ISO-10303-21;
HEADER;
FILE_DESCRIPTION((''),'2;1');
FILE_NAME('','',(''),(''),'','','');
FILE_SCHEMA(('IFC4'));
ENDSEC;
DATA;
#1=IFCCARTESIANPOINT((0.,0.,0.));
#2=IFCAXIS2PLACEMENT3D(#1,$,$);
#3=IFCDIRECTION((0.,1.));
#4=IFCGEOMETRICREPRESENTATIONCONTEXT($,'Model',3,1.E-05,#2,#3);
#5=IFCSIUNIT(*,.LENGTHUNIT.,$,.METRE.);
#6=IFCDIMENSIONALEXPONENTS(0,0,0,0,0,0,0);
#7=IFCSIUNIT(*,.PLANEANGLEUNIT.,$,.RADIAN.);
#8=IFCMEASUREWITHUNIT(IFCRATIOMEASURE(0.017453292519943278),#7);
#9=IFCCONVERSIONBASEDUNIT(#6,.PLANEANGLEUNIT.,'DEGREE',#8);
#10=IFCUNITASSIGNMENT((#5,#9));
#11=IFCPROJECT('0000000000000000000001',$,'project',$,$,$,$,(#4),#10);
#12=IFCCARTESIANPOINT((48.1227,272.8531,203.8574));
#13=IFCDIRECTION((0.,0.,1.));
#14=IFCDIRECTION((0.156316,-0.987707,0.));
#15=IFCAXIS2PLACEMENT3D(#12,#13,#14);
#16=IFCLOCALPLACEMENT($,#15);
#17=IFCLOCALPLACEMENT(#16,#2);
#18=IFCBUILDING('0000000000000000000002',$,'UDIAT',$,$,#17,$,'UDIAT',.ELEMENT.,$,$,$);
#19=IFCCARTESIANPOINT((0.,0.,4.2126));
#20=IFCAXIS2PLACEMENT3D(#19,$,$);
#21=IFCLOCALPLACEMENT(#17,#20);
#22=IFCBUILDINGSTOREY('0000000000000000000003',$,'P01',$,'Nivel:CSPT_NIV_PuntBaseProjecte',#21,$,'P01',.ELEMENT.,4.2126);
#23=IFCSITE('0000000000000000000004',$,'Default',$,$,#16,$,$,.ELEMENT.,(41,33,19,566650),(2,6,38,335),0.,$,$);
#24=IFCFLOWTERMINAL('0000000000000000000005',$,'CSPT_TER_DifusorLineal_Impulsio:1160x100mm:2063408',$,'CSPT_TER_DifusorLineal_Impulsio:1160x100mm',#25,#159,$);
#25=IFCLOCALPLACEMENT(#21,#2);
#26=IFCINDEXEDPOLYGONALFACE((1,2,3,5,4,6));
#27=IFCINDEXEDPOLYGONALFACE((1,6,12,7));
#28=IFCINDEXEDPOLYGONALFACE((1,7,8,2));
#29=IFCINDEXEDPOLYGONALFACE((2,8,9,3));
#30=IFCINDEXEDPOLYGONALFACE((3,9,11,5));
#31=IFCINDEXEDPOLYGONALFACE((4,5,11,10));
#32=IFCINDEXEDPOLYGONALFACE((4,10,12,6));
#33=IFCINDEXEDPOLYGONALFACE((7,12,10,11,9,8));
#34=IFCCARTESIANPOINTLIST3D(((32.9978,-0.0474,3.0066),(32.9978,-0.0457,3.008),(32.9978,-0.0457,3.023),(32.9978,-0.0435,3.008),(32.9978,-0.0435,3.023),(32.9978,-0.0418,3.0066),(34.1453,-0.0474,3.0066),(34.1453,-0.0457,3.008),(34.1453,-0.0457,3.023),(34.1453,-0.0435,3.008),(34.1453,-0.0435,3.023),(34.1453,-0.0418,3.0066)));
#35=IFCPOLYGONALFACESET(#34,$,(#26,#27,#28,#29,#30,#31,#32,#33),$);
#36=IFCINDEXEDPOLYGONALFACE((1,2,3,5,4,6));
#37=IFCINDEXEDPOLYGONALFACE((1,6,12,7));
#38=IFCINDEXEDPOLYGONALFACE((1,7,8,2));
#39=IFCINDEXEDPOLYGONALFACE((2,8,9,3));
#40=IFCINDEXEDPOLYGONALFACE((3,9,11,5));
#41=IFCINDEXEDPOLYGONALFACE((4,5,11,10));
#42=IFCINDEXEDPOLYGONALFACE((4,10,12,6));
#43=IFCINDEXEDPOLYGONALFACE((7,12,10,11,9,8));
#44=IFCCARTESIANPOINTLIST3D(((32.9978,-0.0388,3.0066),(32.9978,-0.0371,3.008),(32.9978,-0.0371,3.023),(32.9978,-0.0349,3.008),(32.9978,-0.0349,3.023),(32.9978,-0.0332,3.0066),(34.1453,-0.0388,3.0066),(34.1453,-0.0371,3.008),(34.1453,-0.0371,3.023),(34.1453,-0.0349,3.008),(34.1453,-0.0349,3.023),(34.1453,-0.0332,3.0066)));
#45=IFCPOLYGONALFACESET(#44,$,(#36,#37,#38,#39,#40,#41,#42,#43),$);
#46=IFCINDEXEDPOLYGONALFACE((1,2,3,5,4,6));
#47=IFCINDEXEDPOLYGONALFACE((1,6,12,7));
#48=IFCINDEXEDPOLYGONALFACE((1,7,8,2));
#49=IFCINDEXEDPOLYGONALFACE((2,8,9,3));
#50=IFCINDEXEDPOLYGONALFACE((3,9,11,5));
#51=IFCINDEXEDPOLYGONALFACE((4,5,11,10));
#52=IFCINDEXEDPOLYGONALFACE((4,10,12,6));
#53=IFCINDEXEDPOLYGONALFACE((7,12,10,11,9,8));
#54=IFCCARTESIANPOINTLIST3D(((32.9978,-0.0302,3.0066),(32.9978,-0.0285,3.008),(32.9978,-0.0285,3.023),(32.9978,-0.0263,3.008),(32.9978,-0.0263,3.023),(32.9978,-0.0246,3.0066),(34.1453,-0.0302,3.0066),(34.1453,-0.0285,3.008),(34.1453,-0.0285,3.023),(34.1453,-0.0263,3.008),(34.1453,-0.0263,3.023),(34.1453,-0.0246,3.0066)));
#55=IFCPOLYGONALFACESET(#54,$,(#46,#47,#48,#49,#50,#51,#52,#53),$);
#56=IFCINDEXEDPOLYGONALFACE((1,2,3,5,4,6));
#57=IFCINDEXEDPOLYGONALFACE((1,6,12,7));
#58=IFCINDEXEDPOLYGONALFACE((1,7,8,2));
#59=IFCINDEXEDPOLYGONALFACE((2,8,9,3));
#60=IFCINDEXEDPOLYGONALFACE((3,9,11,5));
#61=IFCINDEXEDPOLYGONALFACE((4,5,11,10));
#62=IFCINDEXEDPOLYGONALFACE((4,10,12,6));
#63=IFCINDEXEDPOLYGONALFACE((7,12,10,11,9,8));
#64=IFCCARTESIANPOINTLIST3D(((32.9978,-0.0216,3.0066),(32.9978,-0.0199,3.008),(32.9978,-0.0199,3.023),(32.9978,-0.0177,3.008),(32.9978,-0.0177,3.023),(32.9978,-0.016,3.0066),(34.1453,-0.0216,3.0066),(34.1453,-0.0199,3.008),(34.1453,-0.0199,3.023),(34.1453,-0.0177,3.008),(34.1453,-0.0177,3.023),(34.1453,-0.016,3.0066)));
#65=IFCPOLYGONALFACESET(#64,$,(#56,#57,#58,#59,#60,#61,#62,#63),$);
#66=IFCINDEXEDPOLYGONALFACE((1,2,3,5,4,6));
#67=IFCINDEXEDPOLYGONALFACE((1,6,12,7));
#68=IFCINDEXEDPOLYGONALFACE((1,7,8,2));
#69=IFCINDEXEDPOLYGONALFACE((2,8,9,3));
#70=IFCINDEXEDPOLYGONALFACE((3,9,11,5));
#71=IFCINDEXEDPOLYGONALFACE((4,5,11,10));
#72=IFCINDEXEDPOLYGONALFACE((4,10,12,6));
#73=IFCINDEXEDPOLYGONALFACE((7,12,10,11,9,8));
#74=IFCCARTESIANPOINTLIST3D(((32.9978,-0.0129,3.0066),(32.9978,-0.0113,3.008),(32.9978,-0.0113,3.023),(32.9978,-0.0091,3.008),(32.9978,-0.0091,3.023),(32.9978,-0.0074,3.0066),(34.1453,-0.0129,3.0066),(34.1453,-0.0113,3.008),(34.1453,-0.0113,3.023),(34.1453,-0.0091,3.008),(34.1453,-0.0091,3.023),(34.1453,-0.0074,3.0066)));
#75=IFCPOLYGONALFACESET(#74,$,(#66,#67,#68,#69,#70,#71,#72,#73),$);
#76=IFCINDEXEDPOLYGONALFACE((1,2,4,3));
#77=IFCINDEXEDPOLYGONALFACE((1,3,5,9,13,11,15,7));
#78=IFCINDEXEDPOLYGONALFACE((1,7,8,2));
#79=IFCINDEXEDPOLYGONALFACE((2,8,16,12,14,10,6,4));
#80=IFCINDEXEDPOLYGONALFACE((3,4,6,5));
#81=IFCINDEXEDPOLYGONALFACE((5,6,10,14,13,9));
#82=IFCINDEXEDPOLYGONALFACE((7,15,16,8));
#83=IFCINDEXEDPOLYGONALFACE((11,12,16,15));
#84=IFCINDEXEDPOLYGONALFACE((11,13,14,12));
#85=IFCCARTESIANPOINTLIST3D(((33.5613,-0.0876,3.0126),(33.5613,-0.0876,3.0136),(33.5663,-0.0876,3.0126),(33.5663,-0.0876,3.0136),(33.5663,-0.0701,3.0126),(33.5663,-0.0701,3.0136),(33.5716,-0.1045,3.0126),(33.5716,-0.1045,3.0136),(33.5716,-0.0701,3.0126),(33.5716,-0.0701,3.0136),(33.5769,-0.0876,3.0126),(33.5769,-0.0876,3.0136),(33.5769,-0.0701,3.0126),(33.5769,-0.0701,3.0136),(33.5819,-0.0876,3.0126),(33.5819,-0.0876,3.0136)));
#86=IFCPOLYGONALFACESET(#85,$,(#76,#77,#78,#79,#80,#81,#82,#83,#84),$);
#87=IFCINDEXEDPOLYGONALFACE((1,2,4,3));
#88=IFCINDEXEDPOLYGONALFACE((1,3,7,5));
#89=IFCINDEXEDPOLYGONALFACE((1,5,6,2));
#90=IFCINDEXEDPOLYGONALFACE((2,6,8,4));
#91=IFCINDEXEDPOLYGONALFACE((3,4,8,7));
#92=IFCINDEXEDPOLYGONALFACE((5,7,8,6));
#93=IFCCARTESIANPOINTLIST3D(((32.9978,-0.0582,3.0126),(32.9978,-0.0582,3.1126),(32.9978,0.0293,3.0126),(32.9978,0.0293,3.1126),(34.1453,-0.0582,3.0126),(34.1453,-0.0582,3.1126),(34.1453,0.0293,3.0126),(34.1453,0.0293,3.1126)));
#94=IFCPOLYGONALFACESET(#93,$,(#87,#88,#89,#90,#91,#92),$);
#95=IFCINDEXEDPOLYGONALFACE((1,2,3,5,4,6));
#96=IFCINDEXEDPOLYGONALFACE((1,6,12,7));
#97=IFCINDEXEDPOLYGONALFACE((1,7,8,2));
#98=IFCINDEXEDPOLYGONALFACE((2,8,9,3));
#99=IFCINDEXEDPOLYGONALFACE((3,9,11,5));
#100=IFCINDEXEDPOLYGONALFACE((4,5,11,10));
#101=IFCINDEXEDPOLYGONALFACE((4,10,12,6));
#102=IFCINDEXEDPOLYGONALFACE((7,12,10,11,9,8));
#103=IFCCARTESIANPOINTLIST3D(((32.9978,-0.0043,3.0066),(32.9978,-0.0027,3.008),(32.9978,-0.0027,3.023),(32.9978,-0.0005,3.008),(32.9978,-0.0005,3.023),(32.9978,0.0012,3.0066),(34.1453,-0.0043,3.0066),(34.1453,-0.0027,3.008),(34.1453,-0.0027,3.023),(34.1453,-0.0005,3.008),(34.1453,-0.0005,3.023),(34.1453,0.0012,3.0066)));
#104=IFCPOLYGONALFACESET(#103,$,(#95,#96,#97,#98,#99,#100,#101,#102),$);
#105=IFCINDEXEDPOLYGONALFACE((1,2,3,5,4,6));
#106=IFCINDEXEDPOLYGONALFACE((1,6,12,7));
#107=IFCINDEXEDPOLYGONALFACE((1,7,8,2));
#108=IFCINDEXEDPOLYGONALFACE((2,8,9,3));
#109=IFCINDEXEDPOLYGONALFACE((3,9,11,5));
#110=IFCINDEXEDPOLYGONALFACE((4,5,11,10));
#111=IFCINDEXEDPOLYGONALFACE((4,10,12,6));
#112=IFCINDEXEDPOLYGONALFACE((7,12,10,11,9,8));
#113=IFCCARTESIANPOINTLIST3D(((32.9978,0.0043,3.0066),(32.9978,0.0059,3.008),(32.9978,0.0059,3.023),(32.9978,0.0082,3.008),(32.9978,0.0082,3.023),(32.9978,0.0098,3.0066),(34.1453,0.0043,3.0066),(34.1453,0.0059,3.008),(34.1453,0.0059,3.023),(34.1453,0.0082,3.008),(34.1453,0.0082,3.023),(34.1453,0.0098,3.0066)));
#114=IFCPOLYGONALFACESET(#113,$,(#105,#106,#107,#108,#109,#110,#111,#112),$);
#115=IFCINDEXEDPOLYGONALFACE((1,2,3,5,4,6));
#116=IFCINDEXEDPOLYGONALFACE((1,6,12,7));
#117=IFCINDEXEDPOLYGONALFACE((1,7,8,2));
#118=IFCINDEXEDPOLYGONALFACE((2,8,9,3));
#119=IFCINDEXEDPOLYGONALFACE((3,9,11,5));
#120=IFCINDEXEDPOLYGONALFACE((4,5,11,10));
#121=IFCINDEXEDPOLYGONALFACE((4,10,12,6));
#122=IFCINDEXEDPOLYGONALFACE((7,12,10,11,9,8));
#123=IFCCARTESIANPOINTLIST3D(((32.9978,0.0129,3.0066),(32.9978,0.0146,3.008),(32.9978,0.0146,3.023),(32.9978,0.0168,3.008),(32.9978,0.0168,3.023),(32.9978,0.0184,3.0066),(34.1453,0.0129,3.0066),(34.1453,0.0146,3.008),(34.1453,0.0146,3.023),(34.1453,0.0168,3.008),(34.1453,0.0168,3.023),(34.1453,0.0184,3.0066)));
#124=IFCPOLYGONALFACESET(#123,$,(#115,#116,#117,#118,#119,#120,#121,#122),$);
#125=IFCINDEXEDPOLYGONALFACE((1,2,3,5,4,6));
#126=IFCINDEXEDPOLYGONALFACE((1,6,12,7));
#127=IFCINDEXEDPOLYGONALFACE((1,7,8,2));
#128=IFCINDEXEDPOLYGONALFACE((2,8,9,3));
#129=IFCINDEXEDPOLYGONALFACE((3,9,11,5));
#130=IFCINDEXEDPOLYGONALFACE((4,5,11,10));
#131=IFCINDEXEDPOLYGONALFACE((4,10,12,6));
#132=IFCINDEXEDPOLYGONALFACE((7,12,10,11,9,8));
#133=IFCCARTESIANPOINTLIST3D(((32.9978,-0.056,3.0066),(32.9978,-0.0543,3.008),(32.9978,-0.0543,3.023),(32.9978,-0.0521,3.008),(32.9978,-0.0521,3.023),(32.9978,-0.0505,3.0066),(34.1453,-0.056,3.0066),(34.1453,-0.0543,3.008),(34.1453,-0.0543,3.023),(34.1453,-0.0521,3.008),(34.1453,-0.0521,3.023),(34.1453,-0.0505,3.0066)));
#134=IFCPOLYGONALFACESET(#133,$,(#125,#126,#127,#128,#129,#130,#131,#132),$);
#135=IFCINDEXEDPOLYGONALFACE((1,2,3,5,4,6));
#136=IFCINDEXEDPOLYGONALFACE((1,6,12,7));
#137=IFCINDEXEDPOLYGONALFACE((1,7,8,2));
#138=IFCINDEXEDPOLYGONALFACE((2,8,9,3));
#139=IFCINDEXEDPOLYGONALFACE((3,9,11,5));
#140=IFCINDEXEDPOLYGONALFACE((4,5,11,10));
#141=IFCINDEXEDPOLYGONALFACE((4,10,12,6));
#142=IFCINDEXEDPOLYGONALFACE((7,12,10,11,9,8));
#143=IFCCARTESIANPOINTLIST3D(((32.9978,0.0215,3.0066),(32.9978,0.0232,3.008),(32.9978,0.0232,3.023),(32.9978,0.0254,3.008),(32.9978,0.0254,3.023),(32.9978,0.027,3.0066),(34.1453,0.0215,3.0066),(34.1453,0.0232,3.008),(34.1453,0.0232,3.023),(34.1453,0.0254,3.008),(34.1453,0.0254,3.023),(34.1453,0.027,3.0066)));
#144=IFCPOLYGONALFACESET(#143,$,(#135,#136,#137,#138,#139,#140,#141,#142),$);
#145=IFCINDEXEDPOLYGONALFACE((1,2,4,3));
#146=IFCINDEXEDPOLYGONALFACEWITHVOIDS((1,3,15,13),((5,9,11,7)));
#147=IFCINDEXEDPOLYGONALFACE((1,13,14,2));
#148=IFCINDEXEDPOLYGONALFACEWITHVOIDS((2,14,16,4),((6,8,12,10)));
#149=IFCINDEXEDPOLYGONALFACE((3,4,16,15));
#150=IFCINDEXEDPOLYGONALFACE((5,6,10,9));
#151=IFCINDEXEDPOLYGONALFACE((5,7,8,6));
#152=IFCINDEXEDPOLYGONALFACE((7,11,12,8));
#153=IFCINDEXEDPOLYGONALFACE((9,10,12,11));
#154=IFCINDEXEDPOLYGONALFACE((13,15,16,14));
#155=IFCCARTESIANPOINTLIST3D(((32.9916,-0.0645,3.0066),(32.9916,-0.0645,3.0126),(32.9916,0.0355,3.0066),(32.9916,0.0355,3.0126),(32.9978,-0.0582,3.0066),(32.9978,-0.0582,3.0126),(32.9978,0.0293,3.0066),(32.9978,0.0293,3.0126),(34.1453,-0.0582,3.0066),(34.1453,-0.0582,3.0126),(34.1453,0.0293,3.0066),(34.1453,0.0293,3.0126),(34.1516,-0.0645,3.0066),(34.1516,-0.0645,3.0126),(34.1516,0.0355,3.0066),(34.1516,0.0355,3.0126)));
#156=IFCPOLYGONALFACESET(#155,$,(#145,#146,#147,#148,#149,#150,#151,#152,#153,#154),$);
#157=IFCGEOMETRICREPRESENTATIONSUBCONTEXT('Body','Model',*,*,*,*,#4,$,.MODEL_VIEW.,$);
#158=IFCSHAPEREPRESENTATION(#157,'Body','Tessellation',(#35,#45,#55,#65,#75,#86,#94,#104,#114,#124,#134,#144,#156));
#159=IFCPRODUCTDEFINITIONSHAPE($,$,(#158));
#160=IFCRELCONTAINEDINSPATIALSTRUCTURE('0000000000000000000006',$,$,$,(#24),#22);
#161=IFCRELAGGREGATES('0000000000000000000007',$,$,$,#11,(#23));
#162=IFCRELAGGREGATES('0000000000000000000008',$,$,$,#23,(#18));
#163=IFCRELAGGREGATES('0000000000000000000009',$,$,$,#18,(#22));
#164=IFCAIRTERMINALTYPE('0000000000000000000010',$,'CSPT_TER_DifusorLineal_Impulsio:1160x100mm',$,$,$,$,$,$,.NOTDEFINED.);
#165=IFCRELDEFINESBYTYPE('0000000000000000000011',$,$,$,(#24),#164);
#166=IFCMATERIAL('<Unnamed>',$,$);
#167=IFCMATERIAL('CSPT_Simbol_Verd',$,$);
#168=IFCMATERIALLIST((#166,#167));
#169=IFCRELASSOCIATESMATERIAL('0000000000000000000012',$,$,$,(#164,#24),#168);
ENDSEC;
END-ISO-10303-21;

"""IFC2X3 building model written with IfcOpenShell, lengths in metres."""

from ifc_helpers import new_model, entity, si_unit, converted_unit, direction, frame, origin, origin_2d_with_axis, place, context, subcontext, project, spatial, polyline, rectangle, outline, extrude, source, transform, mapped, material, material_list, type_object, type_shapes, element, save


model = new_model("IFC2X3")

# Units and contexts
model_context = context("Model", 3, precision=1e-05, world=origin(), true_north=direction((0.0, 1.0)))
body_context = subcontext(model_context, "Body", "Model", "MODEL_VIEW")
ifc_project = project(units=[si_unit("LENGTHUNIT", "METRE"), converted_unit("PLANEANGLEUNIT", "DEGREE", entity("IfcRatioMeasure", 0.017453292519943278), si_unit("PLANEANGLEUNIT", "RADIAN"), dimensions=[0, 0, 0, 0, 0, 0, 0])], contexts=[model_context])

# Site, building, storey
site_placement = place(None, frame((48.1227, 272.8531, 203.8574), z_axis=(0.0, 0.0, 1.0), x_axis=(0.156316, -0.987707, 0.0)))
site = spatial("IfcSite", under=ifc_project, at=site_placement, Name="Default", CompositionType="ELEMENT", RefLatitude=(41, 33, 19, 566650), RefLongitude=(2, 6, 38, 335), RefElevation=0.0)
building_placement = place(site_placement, origin())
building = spatial("IfcBuilding", under=site, at=building_placement, Name="UDIAT", LongName="UDIAT", CompositionType="ELEMENT")
storey_placement = place(building_placement, frame((0.0, 0.0, 4.2126)))
storey = spatial("IfcBuildingStorey", under=building, at=storey_placement, Name="P01", ObjectType="Nivel:CSPT_NIV_PuntBaseProjecte", LongName="P01", CompositionType="ELEMENT", Elevation=4.2126)

# Shared definitions
ifc_material_1 = material(Name="<Unnamed>")

# Flow terminal
ifc_material_2 = material(Name="CSPT_Simbol_Verd")
ifc_material_list = material_list([ifc_material_1, ifc_material_2])
air_terminal_type = type_object("IfcAirTerminalType", Name="CSPT_TER_DifusorLineal_Impulsio:1160x100mm", PredefinedType="NOTDEFINED", material=ifc_material_list)
shared_shape_1 = source(origin(), body_context, "Body", "SweptSolid", [
    extrude(outline(polyline([(0.0037, 0.0028), (0.0059, 0.0028), (0.0016, 0.0063), (0.002, 0.0042), (-0.0074, -0.0074), (-0.0057, -0.0088), (0.0037, 0.0028)])), frame((-0.5737, 0.0301, -0.0001), z_axis=(1.0, 0.0, 0.0), x_axis=(0.0, -0.776119, -0.630587)), (0.0, 0.0, 1.0), 1.1475),
    extrude(outline(polyline([(0.0037, 0.0028), (0.0059, 0.0028), (0.0016, 0.0063), (0.002, 0.0042), (-0.0074, -0.0074), (-0.0057, -0.0088), (0.0037, 0.0028)])), frame((-0.5737, 0.0215, -0.0001), z_axis=(1.0, 0.0, 0.0), x_axis=(0.0, -0.776119, -0.630587)), (0.0, 0.0, 1.0), 1.1475),
    extrude(outline(polyline([(0.0037, 0.0028), (0.0059, 0.0028), (0.0016, 0.0063), (0.002, 0.0042), (-0.0074, -0.0074), (-0.0057, -0.0088), (0.0037, 0.0028)])), frame((-0.5737, 0.0129, -0.0001), z_axis=(1.0, 0.0, 0.0), x_axis=(0.0, -0.776119, -0.630587)), (0.0, 0.0, 1.0), 1.1475),
    extrude(outline(polyline([(0.0037, 0.0028), (0.0059, 0.0028), (0.0016, 0.0063), (0.002, 0.0042), (-0.0074, -0.0074), (-0.0057, -0.0088), (0.0037, 0.0028)])), frame((-0.5737, 0.0043, -0.0001), z_axis=(1.0, 0.0, 0.0), x_axis=(0.0, -0.776119, -0.630587)), (0.0, 0.0, 1.0), 1.1475),
    extrude(outline(polyline([(0.0037, 0.0028), (0.0059, 0.0028), (0.0016, 0.0063), (0.002, 0.0042), (-0.0074, -0.0074), (-0.0057, -0.0088), (0.0037, 0.0028)])), frame((-0.5737, -0.0043, -0.0001), z_axis=(1.0, 0.0, 0.0), x_axis=(0.0, -0.776119, -0.630587)), (0.0, 0.0, 1.0), 1.1475),
    extrude(outline(polyline([(0.0, -0.013), (0.0053, -0.013), (0.0053, 0.0045), (0.0103, 0.0045), (0.0, 0.0213), (-0.0103, 0.0045), (-0.0053, 0.0045), (-0.0053, -0.013), (0.0, -0.013)])), frame((0.0, 0.0687, 0.0)), (0.0, 0.0, 1.0), 0.001),
    extrude(rectangle(XDim=1.1475, YDim=0.0875, at=origin_2d_with_axis()), frame((0.0, 0.0, 0.0), z_axis=(0.0, 0.0, 1.0), x_axis=(-1.0, 0.0, 0.0)), (0.0, 0.0, 1.0), 0.1),
    extrude(outline(polyline([(0.0037, 0.0028), (0.0059, 0.0028), (0.0016, 0.0063), (0.002, 0.0042), (-0.0074, -0.0074), (-0.0057, -0.0088), (0.0037, 0.0028)])), frame((-0.5737, -0.0129, -0.0001), z_axis=(1.0, 0.0, 0.0), x_axis=(0.0, -0.776119, -0.630587)), (0.0, 0.0, 1.0), 1.1475),
    extrude(outline(polyline([(0.0037, 0.0028), (0.0059, 0.0028), (0.0016, 0.0063), (0.002, 0.0042), (-0.0074, -0.0074), (-0.0057, -0.0088), (0.0037, 0.0028)])), frame((-0.5737, -0.0215, -0.0001), z_axis=(1.0, 0.0, 0.0), x_axis=(0.0, -0.776119, -0.630587)), (0.0, 0.0, 1.0), 1.1475),
    extrude(outline(polyline([(0.0037, 0.0028), (0.0059, 0.0028), (0.0016, 0.0063), (0.002, 0.0042), (-0.0074, -0.0074), (-0.0057, -0.0088), (0.0037, 0.0028)])), frame((-0.5737, -0.0301, -0.0001), z_axis=(1.0, 0.0, 0.0), x_axis=(0.0, -0.776119, -0.630587)), (0.0, 0.0, 1.0), 1.1475),
    extrude(outline(polyline([(0.0037, 0.0028), (0.0059, 0.0028), (0.0016, 0.0063), (0.002, 0.0042), (-0.0074, -0.0074), (-0.0057, -0.0088), (0.0037, 0.0028)])), frame((-0.5737, 0.0388, -0.0001), z_axis=(1.0, 0.0, 0.0), x_axis=(0.0, -0.776119, -0.630587)), (0.0, 0.0, 1.0), 1.1475),
    extrude(outline(polyline([(0.0037, 0.0028), (0.0059, 0.0028), (0.0016, 0.0063), (0.002, 0.0042), (-0.0074, -0.0074), (-0.0057, -0.0088), (0.0037, 0.0028)])), frame((-0.5737, -0.0387, -0.0001), z_axis=(1.0, 0.0, 0.0), x_axis=(0.0, -0.776119, -0.630587)), (0.0, 0.0, 1.0), 1.1475),
    extrude(outline(polyline([(-0.58, -0.05), (0.58, -0.05), (0.58, 0.05), (-0.58, 0.05), (-0.58, -0.05)]), holes=[polyline([(-0.5738, -0.0438), (-0.5738, 0.0437), (0.5737, 0.0437), (0.5737, -0.0438), (-0.5738, -0.0438)])]), frame((0.0, 0.0, -0.006), z_axis=(0.0, 0.0, 1.0), x_axis=(-1.0, 0.0, 0.0)), (0.0, 0.0, 1.0), 0.006),
])
type_shapes(air_terminal_type, [shared_shape_1])
for number, where, z_axis, x_axis, name in (
    (1, (33.5716, -0.0145, 3.0126), (0.0, 0.0, 1.0), (-1.0, 0.0, 0.0), "CSPT_TER_DifusorLineal_Impulsio:1160x100mm:2063408"),
):
    element("IfcFlowTerminal", number, at=place(storey_placement, frame(where, z_axis=z_axis, x_axis=x_axis)), inside=storey, type_object=air_terminal_type, material=ifc_material_list, Name=name, ObjectType="CSPT_TER_DifusorLineal_Impulsio:1160x100mm", context=body_context, shape_type="MappedRepresentation", body=[
        mapped(shared_shape_1, transform((0.0, 0.0, 0.0), scale=1.0)),
    ])

save(model, "model.ifc")
